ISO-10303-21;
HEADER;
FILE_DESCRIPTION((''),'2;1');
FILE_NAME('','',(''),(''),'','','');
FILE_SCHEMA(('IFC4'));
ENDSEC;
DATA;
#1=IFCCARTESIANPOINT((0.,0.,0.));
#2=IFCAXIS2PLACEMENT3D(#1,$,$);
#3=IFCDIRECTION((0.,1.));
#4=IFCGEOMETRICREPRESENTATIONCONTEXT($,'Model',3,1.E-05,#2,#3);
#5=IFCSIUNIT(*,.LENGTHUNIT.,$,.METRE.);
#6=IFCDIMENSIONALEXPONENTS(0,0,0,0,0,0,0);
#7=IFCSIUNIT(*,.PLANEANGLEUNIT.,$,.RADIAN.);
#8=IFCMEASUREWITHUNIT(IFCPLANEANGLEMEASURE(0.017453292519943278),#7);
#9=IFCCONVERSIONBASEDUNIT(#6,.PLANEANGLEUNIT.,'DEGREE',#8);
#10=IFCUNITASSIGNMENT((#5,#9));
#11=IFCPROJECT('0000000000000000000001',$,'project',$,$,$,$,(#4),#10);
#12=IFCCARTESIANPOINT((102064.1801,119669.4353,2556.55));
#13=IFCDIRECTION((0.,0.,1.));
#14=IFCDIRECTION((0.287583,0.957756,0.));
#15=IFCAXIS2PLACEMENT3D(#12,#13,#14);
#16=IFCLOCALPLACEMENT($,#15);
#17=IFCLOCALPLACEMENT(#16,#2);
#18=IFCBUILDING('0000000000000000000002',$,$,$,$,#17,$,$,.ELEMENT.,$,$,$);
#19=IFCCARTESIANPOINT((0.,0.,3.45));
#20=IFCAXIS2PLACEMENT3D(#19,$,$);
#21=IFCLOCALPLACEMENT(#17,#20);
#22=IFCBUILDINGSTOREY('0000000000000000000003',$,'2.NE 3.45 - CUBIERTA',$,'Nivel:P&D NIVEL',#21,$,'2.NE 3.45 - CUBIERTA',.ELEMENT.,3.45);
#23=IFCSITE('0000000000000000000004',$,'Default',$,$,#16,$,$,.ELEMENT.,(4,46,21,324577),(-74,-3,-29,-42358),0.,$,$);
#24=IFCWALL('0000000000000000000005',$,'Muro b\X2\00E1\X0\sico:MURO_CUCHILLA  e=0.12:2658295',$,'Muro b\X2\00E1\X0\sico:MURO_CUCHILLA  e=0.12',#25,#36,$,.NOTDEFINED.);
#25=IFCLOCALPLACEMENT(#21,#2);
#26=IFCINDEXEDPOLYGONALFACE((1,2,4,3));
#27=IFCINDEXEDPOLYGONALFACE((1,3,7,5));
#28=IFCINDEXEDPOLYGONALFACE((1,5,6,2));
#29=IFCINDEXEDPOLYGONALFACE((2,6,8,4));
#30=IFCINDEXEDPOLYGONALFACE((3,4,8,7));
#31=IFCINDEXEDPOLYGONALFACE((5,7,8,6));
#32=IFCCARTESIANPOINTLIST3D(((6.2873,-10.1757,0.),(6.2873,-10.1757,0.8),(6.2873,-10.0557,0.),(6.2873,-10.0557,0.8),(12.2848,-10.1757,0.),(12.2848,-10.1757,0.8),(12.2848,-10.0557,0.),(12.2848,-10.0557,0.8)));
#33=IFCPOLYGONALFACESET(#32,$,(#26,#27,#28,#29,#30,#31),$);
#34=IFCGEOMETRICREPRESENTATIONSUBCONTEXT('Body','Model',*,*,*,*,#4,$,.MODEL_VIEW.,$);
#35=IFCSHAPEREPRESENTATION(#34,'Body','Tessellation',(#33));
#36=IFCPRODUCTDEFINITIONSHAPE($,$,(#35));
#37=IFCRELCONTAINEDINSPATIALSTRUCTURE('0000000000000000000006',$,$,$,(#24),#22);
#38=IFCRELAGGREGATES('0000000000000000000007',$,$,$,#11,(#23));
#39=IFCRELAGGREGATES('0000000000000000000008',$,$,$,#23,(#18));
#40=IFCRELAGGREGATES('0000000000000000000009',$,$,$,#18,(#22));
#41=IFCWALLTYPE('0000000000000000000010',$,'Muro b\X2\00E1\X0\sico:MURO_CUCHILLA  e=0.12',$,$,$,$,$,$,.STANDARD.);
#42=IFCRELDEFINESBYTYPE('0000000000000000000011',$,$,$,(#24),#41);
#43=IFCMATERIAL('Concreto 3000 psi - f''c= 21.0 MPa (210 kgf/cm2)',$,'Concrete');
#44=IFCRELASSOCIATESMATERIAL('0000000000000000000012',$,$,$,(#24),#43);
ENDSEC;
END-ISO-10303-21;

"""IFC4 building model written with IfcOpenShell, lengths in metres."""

from ifc_helpers import new_model, entity, si_unit, converted_unit, direction, frame, origin, place, context, subcontext, project, spatial, indexed_curve, outline, extrude, material, type_object, element, save


model = new_model("IFC4")

# Units and contexts
model_context = context("Model", 3, precision=1e-05, world=origin(), true_north=direction((0.0, 1.0)))
body_context = subcontext(model_context, "Body", "Model", "MODEL_VIEW")
ifc_project = project(units=[si_unit("LENGTHUNIT", "METRE"), converted_unit("PLANEANGLEUNIT", "DEGREE", entity("IfcPlaneAngleMeasure", 0.017453292519943278), si_unit("PLANEANGLEUNIT", "RADIAN"), dimensions=[0, 0, 0, 0, 0, 0, 0])], contexts=[model_context])

# Site, building, storey
site_placement = place(None, frame((102064.1801, 119669.4353, 2556.55), z_axis=(0.0, 0.0, 1.0), x_axis=(0.287583, 0.957756, 0.0)))
site = spatial("IfcSite", under=ifc_project, at=site_placement, Name="Default", CompositionType="ELEMENT", RefLatitude=(4, 46, 21, 324577), RefLongitude=(-74, -3, -29, -42358), RefElevation=0.0)
building_placement = place(site_placement, origin())
building = spatial("IfcBuilding", under=site, at=building_placement, CompositionType="ELEMENT")
storey_placement = place(building_placement, frame((0.0, 0.0, 3.45)))
storey = spatial("IfcBuildingStorey", under=building, at=storey_placement, Name="2.NE 3.45 - CUBIERTA", ObjectType="Nivel:P&D NIVEL", LongName="2.NE 3.45 - CUBIERTA", CompositionType="ELEMENT", Elevation=3.45)

# Shared definitions
ifc_material_1 = material(Name="Concreto 3000 psi - f'c= 21.0 MPa (210 kgf/cm2)", Category="Concrete")

# Wall
wall_type = type_object("IfcWallType", Name="Muro básico:MURO_CUCHILLA  e=0.12", PredefinedType="STANDARD")
wall_1_placement = place(storey_placement, frame((12.2848, -10.1157, 0.0), z_axis=(0.0, 0.0, 1.0), x_axis=(-1.0, 0.0, 0.0)))
element("IfcWall", 1, at=wall_1_placement, inside=storey, type_object=wall_type, material=ifc_material_1, Name="Muro básico:MURO_CUCHILLA  e=0.12:2658295", ObjectType="Muro básico:MURO_CUCHILLA  e=0.12", PredefinedType="NOTDEFINED", context=body_context, shape_type="SweptSolid", body=[
    extrude(outline(indexed_curve([(5.9975, 0.06), (0.0, 0.06), (0.0, -0.06), (5.9975, -0.06), (5.9975, 0.06)], self_intersect=False)), origin(), (0.0, 0.0, 1.0), 0.8),
])

save(model, "model.ifc")
